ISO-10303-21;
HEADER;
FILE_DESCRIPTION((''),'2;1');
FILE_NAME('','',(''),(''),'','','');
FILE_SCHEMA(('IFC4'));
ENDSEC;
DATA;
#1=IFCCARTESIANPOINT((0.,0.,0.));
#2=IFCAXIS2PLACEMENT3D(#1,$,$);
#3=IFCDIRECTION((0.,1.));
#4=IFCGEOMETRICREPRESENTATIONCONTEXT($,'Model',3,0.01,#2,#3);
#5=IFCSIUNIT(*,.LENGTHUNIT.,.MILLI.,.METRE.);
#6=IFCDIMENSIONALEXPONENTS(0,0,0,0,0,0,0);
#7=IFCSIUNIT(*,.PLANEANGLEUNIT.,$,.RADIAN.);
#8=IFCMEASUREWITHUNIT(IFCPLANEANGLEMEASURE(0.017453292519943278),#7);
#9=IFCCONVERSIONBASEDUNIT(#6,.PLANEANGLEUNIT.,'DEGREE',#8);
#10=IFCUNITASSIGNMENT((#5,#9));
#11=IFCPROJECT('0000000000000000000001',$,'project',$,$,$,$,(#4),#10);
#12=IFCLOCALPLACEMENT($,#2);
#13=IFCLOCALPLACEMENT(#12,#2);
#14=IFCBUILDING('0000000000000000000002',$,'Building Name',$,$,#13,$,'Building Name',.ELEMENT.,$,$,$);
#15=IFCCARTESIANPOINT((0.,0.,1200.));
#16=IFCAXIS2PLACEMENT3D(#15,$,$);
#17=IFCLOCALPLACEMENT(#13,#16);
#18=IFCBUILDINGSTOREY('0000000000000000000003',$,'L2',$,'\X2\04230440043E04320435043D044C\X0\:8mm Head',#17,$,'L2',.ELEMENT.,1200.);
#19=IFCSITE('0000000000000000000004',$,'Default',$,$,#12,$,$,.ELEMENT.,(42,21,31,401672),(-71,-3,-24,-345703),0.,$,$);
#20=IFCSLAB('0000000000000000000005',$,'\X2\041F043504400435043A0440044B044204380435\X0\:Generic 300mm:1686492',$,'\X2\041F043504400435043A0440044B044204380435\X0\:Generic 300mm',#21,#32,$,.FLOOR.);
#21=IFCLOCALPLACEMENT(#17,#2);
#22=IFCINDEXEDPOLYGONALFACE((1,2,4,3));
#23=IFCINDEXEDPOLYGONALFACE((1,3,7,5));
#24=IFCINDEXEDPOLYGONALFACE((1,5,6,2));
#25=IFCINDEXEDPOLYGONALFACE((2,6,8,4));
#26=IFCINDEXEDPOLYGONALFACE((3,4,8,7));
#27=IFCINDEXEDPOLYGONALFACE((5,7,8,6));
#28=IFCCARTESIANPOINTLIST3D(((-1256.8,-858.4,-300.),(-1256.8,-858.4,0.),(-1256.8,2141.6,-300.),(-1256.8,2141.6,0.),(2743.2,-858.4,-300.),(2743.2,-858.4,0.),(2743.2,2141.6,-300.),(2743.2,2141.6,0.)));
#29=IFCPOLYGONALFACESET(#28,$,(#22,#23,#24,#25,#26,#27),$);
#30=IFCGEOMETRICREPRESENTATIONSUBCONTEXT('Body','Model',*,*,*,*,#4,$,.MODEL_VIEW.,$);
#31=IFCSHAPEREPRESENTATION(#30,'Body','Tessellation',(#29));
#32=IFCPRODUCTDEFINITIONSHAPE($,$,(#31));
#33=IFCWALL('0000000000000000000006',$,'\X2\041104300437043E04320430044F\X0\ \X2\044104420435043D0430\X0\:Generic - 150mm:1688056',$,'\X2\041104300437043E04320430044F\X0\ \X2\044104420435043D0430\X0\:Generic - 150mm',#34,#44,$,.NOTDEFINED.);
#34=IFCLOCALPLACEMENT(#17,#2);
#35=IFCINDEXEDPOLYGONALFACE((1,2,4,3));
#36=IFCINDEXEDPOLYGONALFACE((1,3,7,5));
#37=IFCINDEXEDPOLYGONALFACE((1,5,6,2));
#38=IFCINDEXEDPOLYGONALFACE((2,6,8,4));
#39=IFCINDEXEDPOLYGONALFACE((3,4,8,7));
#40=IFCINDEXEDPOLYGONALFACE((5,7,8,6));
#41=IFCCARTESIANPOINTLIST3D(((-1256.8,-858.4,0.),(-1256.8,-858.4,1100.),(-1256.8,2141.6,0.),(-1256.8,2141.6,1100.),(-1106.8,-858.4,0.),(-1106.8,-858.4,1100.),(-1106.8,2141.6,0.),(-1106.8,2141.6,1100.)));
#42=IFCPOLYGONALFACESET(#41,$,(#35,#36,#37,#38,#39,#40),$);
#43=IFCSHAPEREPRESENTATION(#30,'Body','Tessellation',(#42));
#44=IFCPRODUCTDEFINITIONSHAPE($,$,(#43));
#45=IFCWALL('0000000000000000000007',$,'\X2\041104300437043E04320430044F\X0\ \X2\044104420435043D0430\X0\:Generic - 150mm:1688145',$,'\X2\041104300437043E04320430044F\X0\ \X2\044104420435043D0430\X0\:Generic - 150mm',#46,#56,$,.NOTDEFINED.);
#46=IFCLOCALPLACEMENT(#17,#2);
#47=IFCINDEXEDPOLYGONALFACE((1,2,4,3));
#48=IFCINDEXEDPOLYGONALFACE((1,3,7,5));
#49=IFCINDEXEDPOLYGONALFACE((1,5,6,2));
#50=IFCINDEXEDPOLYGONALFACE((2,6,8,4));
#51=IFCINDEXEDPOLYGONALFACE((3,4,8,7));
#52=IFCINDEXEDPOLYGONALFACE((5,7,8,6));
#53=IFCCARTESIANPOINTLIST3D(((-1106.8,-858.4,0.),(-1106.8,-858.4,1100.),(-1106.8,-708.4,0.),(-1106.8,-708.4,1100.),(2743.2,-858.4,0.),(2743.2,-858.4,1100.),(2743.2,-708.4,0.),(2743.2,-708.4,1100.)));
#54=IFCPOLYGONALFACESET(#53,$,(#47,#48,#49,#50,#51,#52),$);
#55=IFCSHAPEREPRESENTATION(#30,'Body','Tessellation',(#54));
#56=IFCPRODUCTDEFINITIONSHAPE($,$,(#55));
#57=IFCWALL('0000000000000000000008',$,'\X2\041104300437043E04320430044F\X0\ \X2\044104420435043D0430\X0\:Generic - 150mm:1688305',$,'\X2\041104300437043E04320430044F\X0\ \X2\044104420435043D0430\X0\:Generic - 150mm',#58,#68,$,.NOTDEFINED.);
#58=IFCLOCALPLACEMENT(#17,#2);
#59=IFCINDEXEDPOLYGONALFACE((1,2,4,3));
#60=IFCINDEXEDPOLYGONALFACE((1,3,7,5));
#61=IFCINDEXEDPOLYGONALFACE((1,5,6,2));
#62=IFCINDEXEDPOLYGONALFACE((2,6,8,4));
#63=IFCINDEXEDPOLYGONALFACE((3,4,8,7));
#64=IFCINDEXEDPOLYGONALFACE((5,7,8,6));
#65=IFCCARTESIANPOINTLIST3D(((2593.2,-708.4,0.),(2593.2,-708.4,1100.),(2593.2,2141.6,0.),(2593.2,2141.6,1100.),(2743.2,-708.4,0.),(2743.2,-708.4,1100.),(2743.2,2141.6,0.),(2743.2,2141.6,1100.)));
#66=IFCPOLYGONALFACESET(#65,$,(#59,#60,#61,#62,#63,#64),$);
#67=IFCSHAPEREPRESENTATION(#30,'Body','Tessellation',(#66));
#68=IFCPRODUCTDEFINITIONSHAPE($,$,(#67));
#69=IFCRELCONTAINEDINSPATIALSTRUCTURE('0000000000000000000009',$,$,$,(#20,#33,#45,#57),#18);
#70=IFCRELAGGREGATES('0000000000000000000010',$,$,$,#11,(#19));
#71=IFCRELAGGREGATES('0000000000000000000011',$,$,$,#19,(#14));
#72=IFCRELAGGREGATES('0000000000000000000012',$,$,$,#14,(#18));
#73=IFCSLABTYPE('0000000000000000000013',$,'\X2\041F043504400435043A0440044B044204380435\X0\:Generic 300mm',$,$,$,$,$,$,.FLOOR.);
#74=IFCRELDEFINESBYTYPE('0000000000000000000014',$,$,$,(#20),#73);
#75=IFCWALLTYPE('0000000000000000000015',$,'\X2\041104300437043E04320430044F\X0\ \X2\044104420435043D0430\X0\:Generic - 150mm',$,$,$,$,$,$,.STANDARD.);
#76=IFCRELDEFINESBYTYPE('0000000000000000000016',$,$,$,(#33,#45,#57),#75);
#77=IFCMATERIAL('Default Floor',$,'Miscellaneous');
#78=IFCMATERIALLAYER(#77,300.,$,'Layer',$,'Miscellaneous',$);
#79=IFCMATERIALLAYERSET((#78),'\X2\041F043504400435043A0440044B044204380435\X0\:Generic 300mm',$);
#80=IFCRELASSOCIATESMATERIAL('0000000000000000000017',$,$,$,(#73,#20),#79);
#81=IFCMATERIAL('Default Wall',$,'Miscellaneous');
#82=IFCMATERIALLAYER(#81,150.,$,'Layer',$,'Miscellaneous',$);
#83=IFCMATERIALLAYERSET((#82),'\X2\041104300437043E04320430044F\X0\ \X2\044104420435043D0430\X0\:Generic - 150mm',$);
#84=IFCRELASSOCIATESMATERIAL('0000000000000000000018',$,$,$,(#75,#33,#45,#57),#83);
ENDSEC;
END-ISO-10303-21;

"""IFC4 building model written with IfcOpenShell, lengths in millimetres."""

from ifc_helpers import new_model, entity, si_unit, converted_unit, direction, frame, frame_2d, origin, origin_2d_with_axis, place, context, subcontext, project, spatial, rectangle, extrude, material, layer, layer_set, layer_usage, type_object, element, save


model = new_model("IFC4")

# Units and contexts
model_context = context("Model", 3, precision=0.01, world=origin(), true_north=direction((0.0, 1.0)))
body_context = subcontext(model_context, "Body", "Model", "MODEL_VIEW")
ifc_project = project(units=[si_unit("LENGTHUNIT", "METRE", prefix="MILLI"), converted_unit("PLANEANGLEUNIT", "DEGREE", entity("IfcPlaneAngleMeasure", 0.017453292519943278), si_unit("PLANEANGLEUNIT", "RADIAN"), dimensions=[0, 0, 0, 0, 0, 0, 0])], contexts=[model_context])

# Site, building, storey
site_placement = place(None, origin())
site = spatial("IfcSite", under=ifc_project, at=site_placement, Name="Default", CompositionType="ELEMENT", RefLatitude=(42, 21, 31, 401672), RefLongitude=(-71, -3, -24, -345703), RefElevation=0.0)
building_placement = place(site_placement, origin())
building = spatial("IfcBuilding", under=site, at=building_placement, Name="Building Name", LongName="Building Name", CompositionType="ELEMENT")
storey_placement = place(building_placement, frame((0.0, 0.0, 1200.0)))
storey = spatial("IfcBuildingStorey", under=building, at=storey_placement, Name="L2", ObjectType="Уровень:8mm Head", LongName="L2", CompositionType="ELEMENT", Elevation=1200.0)

# Slab
ifc_material_1 = material(Name="Default Floor", Category="Miscellaneous")
ifc_layer_1 = layer(ifc_material_1, 300.0, Name="Layer", Category="Miscellaneous")
ifc_layer_set_1 = layer_set([ifc_layer_1], Name="Перекрытие:Generic 300mm")
ifc_layer_usage_1 = layer_usage(ifc_layer_set_1, "AXIS3", "POSITIVE", 0.0)
slab_type = type_object("IfcSlabType", Name="Перекрытие:Generic 300mm", PredefinedType="FLOOR", material=ifc_layer_set_1)
slab_placement = place(storey_placement, origin())
element("IfcSlab", 1, at=slab_placement, inside=storey, type_object=slab_type, material=ifc_layer_usage_1, Name="Перекрытие:Generic 300mm:1686492", ObjectType="Перекрытие:Generic 300mm", PredefinedType="FLOOR", context=body_context, shape_type="SweptSolid", body=[
    extrude(rectangle(XDim=3000.0, YDim=4000.0, at=origin_2d_with_axis()), frame((743.2, 641.6, 0.0), z_axis=(0.0, 0.0, -1.0), x_axis=(0.0, 1.0, 0.0)), (0.0, 0.0, 1.0), 300.0),
])

# Walls
ifc_material_2 = material(Name="Default Wall", Category="Miscellaneous")
ifc_layer_2 = layer(ifc_material_2, 150.0, Name="Layer", Category="Miscellaneous")
ifc_layer_set_2 = layer_set([ifc_layer_2], Name="Базовая стена:Generic - 150mm")
ifc_layer_usage_2 = layer_usage(ifc_layer_set_2, "AXIS2", "NEGATIVE", 75.0)
wall_type = type_object("IfcWallType", Name="Базовая стена:Generic - 150mm", PredefinedType="STANDARD", material=ifc_layer_set_2)
wall_1_placement = place(storey_placement, frame((-1181.8, 2141.6, 0.0), z_axis=(0.0, 0.0, 1.0), x_axis=(0.0, -1.0, 0.0)))
element("IfcWall", 2, at=wall_1_placement, inside=storey, type_object=wall_type, material=ifc_layer_usage_2, Name="Базовая стена:Generic - 150mm:1688056", ObjectType="Базовая стена:Generic - 150mm", PredefinedType="NOTDEFINED", context=body_context, shape_type="SweptSolid", body=[
    extrude(rectangle(XDim=3000.0, YDim=150.0, at=frame_2d((1500.0, 0.0), x_axis=(-1.0, 0.0))), origin(), (0.0, 0.0, 1.0), 1100.0),
])
ifc_layer_usage_3 = layer_usage(ifc_layer_set_2, "AXIS2", "NEGATIVE", 75.0)
wall_2_placement = place(storey_placement, frame((-1106.8, -783.4, 0.0)))
element("IfcWall", 3, at=wall_2_placement, inside=storey, type_object=wall_type, material=ifc_layer_usage_3, Name="Базовая стена:Generic - 150mm:1688145", ObjectType="Базовая стена:Generic - 150mm", PredefinedType="NOTDEFINED", context=body_context, shape_type="SweptSolid", body=[
    extrude(rectangle(XDim=3850.0, YDim=150.0, at=frame_2d((1925.0, 0.0), x_axis=(-1.0, 0.0))), origin(), (0.0, 0.0, 1.0), 1100.0),
])
ifc_layer_usage_4 = layer_usage(ifc_layer_set_2, "AXIS2", "NEGATIVE", 75.0)
wall_3_placement = place(storey_placement, frame((2668.2, -708.4, 0.0), z_axis=(0.0, 0.0, 1.0), x_axis=(0.0, 1.0, 0.0)))
element("IfcWall", 4, at=wall_3_placement, inside=storey, type_object=wall_type, material=ifc_layer_usage_4, Name="Базовая стена:Generic - 150mm:1688305", ObjectType="Базовая стена:Generic - 150mm", PredefinedType="NOTDEFINED", context=body_context, shape_type="SweptSolid", body=[
    extrude(rectangle(XDim=2850.0, YDim=150.0, at=frame_2d((1425.0, 0.0), x_axis=(-1.0, 0.0))), origin(), (0.0, 0.0, 1.0), 1100.0),
])

save(model, "model.ifc")
